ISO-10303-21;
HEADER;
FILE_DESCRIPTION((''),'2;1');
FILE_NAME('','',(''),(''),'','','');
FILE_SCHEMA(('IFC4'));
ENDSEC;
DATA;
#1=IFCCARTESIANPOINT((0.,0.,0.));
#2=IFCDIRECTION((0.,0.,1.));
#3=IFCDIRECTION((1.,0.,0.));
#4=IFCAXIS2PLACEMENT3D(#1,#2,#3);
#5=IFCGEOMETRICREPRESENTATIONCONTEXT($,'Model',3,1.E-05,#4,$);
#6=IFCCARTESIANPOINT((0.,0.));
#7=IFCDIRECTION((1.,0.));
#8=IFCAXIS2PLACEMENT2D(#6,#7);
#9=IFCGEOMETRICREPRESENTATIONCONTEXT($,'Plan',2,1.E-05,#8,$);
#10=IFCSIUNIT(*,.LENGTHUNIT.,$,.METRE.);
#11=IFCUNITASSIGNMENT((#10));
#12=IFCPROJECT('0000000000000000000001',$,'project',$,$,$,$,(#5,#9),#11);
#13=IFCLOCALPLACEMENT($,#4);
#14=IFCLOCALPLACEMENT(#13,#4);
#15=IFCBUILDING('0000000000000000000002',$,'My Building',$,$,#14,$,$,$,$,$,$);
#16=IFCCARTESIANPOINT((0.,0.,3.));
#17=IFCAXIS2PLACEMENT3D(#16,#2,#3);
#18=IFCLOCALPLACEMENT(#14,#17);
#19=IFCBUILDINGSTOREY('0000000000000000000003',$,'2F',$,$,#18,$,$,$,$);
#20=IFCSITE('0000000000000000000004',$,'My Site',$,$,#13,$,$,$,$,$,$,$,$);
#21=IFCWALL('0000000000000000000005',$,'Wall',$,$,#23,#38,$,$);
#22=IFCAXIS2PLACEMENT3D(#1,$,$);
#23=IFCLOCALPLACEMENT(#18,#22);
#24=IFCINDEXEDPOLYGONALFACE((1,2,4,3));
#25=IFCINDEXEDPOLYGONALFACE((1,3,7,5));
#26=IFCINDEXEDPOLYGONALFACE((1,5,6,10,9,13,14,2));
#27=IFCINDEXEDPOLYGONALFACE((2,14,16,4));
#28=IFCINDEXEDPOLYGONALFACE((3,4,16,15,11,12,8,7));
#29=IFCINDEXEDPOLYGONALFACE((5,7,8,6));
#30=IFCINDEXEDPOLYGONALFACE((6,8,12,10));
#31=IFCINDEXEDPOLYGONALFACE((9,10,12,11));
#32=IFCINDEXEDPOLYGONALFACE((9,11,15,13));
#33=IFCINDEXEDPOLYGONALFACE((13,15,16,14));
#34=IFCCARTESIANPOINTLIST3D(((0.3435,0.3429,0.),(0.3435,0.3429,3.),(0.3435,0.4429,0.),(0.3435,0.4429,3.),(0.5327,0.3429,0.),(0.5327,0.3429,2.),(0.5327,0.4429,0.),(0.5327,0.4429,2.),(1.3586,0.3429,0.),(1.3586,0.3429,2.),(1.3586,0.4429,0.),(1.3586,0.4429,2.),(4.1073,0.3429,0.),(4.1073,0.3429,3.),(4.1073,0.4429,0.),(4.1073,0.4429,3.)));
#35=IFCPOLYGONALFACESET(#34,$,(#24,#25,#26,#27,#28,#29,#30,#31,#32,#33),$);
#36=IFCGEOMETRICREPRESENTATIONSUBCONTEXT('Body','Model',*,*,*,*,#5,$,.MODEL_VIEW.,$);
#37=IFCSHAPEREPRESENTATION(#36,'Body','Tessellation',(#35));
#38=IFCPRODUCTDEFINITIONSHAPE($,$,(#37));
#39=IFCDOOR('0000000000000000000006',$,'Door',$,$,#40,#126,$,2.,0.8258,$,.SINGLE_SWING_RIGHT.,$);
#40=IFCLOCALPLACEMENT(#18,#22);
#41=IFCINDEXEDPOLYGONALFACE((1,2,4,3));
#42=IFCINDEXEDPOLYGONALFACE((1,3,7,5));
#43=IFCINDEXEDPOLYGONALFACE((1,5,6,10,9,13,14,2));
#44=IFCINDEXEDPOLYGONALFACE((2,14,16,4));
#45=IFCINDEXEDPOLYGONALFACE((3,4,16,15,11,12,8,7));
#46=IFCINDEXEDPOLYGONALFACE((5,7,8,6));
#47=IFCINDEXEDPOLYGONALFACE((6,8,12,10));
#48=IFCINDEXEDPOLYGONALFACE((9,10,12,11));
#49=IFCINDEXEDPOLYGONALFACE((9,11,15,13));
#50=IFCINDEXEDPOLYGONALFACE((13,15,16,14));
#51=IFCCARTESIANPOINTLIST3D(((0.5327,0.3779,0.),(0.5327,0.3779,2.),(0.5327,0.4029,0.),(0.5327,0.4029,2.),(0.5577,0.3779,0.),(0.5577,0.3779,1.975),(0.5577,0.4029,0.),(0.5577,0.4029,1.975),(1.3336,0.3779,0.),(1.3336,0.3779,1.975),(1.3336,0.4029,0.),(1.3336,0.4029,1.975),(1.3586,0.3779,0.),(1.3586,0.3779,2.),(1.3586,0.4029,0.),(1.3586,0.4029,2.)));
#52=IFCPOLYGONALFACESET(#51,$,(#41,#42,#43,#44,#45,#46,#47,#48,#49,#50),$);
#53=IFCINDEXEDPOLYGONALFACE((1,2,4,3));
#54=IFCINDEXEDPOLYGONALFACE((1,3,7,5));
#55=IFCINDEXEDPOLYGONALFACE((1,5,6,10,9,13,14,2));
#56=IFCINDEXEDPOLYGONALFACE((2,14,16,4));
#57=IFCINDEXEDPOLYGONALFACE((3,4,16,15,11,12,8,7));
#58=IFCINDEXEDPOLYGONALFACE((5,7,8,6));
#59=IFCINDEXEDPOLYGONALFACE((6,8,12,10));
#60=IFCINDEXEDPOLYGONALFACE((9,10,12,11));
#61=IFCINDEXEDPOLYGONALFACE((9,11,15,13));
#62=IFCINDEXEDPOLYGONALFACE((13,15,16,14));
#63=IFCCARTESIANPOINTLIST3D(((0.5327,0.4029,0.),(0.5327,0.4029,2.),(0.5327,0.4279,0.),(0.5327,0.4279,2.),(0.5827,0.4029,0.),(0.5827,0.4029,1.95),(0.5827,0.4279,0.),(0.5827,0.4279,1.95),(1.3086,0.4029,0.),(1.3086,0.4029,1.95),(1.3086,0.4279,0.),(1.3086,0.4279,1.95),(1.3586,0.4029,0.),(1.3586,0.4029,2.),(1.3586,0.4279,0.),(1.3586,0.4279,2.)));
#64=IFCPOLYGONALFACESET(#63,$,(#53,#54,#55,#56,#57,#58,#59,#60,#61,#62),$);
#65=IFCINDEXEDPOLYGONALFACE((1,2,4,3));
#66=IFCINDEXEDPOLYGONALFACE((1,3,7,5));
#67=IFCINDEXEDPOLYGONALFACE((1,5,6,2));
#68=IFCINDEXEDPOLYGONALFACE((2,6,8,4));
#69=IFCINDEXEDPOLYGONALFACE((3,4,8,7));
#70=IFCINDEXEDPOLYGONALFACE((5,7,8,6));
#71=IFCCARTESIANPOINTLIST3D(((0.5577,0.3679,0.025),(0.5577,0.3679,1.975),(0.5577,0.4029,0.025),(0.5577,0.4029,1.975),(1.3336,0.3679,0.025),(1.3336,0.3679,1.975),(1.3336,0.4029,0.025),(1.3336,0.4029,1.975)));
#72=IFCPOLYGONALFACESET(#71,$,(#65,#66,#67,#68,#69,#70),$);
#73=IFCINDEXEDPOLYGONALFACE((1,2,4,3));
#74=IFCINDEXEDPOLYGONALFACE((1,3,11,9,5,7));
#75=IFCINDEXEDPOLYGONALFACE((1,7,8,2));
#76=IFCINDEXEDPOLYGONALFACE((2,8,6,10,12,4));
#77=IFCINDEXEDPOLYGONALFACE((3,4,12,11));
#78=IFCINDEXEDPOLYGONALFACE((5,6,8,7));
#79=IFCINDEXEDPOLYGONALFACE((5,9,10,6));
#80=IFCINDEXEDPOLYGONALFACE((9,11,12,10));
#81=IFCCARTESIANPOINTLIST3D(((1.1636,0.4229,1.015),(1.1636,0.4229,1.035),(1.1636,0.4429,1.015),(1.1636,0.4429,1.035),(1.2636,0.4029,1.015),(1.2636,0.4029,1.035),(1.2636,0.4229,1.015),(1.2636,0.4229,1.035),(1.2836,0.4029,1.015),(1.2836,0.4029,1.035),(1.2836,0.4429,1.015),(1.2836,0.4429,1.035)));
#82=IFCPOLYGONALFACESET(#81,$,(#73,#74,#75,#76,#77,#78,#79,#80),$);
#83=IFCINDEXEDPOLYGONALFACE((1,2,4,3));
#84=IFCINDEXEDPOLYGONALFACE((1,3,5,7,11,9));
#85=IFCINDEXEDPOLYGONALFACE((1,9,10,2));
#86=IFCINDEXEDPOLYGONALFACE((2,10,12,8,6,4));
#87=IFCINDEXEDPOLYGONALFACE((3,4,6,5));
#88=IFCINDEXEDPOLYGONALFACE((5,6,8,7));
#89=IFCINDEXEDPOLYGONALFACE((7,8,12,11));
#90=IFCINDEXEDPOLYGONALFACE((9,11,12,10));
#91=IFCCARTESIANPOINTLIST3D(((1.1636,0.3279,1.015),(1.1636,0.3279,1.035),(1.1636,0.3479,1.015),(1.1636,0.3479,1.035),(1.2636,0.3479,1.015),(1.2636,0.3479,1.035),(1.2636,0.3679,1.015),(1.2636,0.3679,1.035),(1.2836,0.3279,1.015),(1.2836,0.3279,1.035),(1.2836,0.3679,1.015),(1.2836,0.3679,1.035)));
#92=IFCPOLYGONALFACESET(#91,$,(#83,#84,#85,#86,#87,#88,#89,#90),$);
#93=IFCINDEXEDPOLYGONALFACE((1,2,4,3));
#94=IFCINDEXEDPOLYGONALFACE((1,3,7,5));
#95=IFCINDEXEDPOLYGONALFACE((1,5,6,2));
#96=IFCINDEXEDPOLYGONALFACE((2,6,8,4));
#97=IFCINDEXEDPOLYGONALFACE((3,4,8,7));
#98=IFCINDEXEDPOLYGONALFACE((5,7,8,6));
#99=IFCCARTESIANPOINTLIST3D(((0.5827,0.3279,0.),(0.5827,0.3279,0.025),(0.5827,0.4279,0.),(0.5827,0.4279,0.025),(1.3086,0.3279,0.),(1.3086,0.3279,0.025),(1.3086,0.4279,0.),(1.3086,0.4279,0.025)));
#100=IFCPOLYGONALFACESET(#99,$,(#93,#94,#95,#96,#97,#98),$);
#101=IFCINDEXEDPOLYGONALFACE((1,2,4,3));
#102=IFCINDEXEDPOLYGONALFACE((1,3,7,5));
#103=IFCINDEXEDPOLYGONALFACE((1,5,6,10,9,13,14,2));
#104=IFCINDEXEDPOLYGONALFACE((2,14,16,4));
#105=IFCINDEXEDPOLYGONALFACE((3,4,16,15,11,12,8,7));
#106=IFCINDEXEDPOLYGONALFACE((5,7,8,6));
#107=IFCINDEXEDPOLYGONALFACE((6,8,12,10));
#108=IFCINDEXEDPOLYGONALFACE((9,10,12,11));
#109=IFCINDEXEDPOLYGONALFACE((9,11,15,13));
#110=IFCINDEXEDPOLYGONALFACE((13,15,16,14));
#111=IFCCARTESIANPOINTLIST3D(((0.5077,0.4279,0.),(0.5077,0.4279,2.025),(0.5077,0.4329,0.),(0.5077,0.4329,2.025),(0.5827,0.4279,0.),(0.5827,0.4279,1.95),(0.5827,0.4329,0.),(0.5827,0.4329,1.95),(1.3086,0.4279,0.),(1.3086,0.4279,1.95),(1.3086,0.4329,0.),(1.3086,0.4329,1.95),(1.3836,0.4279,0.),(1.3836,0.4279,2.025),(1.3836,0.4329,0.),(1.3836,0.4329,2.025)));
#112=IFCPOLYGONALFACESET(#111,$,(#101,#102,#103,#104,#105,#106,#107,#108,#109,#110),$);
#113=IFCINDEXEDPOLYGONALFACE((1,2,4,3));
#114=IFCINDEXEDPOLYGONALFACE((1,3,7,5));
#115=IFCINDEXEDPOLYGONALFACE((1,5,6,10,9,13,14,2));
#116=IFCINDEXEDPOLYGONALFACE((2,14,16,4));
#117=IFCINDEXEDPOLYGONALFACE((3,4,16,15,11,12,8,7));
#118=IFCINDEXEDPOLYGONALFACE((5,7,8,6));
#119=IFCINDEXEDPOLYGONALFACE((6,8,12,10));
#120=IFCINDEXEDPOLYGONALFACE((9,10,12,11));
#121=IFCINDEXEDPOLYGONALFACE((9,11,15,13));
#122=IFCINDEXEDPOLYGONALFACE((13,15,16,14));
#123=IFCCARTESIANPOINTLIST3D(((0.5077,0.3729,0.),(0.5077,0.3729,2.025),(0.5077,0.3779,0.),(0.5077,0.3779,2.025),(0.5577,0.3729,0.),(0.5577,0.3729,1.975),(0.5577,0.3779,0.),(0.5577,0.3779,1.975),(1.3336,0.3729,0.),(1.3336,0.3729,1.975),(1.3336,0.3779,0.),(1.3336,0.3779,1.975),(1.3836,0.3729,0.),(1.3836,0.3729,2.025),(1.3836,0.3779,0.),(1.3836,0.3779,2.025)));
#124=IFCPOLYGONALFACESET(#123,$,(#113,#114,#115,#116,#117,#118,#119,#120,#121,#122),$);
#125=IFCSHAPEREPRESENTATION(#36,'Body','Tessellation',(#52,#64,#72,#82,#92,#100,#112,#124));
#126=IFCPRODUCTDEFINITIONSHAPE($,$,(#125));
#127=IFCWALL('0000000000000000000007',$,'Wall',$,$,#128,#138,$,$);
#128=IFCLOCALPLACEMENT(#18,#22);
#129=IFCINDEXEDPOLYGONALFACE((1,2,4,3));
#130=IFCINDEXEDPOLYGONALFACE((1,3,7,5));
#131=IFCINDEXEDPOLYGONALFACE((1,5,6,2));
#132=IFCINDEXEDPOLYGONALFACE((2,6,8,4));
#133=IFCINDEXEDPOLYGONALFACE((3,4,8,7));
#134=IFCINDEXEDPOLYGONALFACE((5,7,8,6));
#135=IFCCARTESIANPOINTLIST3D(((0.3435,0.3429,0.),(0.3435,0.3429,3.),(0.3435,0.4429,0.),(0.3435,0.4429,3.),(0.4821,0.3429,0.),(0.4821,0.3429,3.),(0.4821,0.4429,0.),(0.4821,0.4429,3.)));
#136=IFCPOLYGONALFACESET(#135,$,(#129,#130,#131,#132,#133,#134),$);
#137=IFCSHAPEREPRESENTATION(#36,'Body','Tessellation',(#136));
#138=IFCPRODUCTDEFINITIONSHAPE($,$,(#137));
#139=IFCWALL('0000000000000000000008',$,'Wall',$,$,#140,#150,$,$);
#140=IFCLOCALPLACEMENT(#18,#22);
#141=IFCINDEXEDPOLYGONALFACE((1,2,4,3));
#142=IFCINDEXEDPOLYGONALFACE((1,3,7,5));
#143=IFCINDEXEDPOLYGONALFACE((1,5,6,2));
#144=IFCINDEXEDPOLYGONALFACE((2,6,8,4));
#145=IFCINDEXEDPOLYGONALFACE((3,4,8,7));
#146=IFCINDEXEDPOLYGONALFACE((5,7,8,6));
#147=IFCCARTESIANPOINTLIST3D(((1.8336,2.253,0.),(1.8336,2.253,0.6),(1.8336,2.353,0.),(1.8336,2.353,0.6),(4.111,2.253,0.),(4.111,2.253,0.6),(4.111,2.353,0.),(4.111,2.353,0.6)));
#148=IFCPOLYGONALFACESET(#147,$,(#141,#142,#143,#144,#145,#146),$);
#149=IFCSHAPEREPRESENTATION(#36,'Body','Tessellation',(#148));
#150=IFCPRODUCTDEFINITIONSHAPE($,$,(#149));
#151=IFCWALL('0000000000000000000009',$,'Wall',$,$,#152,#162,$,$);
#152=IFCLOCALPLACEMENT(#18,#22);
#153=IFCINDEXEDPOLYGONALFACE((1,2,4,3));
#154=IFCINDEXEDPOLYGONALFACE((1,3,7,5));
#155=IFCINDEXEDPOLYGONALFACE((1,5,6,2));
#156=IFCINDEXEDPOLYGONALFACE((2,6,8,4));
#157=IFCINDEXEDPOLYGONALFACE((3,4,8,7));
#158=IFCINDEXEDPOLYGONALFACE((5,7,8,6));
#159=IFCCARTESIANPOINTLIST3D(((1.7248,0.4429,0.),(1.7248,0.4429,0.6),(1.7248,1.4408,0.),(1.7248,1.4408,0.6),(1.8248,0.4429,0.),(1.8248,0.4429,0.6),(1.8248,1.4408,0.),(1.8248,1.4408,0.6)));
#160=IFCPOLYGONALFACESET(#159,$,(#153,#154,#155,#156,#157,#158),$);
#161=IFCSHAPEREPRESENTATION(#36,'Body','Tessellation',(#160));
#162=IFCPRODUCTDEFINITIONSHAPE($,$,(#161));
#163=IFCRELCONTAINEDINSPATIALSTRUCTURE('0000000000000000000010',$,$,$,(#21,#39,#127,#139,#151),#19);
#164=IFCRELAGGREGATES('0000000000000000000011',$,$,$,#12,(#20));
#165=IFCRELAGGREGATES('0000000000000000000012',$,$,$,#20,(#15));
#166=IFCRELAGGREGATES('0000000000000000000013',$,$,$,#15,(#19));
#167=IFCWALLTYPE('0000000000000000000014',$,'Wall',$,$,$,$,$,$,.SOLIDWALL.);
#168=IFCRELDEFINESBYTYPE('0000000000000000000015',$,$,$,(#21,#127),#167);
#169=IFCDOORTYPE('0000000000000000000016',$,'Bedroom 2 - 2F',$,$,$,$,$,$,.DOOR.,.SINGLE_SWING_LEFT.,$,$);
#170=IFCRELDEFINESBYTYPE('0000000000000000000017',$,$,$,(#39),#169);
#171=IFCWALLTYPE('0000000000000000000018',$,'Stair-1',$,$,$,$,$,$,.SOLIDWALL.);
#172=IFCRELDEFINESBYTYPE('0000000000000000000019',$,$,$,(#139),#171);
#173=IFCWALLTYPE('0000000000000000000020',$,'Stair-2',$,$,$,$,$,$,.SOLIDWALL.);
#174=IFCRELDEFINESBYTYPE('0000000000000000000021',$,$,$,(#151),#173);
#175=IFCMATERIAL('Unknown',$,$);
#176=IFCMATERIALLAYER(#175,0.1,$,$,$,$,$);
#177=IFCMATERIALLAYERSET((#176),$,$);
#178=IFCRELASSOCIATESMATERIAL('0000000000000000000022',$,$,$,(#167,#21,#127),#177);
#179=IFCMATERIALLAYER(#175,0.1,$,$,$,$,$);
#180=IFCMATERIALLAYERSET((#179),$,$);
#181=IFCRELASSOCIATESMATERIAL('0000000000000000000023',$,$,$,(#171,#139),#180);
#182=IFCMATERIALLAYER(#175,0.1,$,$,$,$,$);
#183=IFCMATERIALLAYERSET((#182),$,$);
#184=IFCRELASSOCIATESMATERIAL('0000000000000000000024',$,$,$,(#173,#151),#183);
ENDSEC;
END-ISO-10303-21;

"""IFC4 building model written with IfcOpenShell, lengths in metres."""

from ifc_helpers import new_model, entity, si_unit, frame, origin_with_axes, origin_2d_with_axis, place, context, subcontext, project, spatial, line, indexed_curve, outline, extrude, shape, source, transform, mapped, material, layer, layer_set, layer_usage, type_object, type_shapes, element, fill, save


model = new_model("IFC4")

# Units and contexts
model_context = context("Model", 3, precision=1e-05, world=origin_with_axes())
plan_context = context("Plan", 2, precision=1e-05, world=origin_2d_with_axis())
body_context_1 = subcontext(model_context, "Body", "Model", "MODEL_VIEW")
body_context_2 = subcontext(plan_context, "Body", "Plan", "PLAN_VIEW")
ifc_project = project(units=[si_unit("LENGTHUNIT", "METRE")], contexts=[model_context, plan_context])

# Site, building, storey
site_placement = place(None, origin_with_axes())
site = spatial("IfcSite", under=ifc_project, at=site_placement, Name="My Site")
building_placement = place(site_placement, origin_with_axes())
building = spatial("IfcBuilding", under=site, at=building_placement, Name="My Building")
storey_placement = place(building_placement, frame((0.0, 0.0, 3.0), z_axis=(0.0, 0.0, 1.0), x_axis=(1.0, 0.0, 0.0)))
storey = spatial("IfcBuildingStorey", under=building, at=storey_placement, Name="2F")

# Shared definitions
ifc_material_1 = material(Name="Unknown")
ifc_layer_1 = layer(ifc_material_1, 0.1)
ifc_layer_set_1 = layer_set([ifc_layer_1])
wall_type_1 = type_object("IfcWallType", Name="Wall", PredefinedType="SOLIDWALL", material=ifc_layer_set_1)

# Wall, opening, door
ifc_layer_usage_1 = layer_usage(ifc_layer_set_1, "AXIS2", "POSITIVE", 0.0)
wall_1_placement = place(storey_placement, frame((4.2073, 0.4429, 0.0), z_axis=(0.0, 0.0, 1.0), x_axis=(-1.0, 0.0, 0.0)))
wall_1 = element("IfcWall", 1, at=wall_1_placement, inside=storey, type_object=wall_type_1, material=ifc_layer_usage_1, Name="Wall", context=body_context_1, shape_type="SweptSolid", body=[
    extrude(outline(indexed_curve([(0.1, 0.0), (0.1, 0.1), (3.8638, 0.1), (3.8638, 0.0)], segments=[line(1, 2, 3, 4, 1)])), origin_with_axes(), (0.0, 0.0, 1.0), 3.0),
])
shared_shape_1 = source(origin_with_axes(), body_context_1, "Body", "SweptSolid", [
    extrude(outline(indexed_curve([(0.0, 0.0), (0.8258, 0.0), (0.8258, 2.0), (0.0, 2.0)], segments=[line(1, 2, 3, 4, 1)])), frame((0.0, -0.6, 0.0), z_axis=(0.0, -1.0, 0.0), x_axis=(1.0, 0.0, 0.0)), (0.0, 0.0, -1.0), 1.2),
])
opening_1_placement = place(wall_1_placement, frame((2.8487, 0.015, 0.0), z_axis=(0.0, 0.0, 1.0), x_axis=(1.0, -0.000001, 0.0)))
opening_1 = element("IfcOpeningElement", 2, at=opening_1_placement, cuts=wall_1, PredefinedType="OPENING", context=body_context_1, shape_type="MappedRepresentation", body=[
    mapped(shared_shape_1, transform((0.0, 0.0, 0.0), x_axis=(1.0, 0.0, 0.0), y_axis=(0.0, 1.0, 0.0), z_axis=(0.0, 0.0, 1.0), scale=1.0)),
])
door_type_1 = type_object("IfcDoorType", Name="Bedroom 2 - 2F", OperationType="SINGLE_SWING_LEFT", PredefinedType="DOOR")
shared_shape_2 = source(origin_with_axes(), body_context_1, "Body", "SweptSolid", [
    extrude(outline(indexed_curve([(0.0, 0.0), (0.0, 2.0), (0.8258, 2.0), (0.8258, 0.0), (0.8008, 0.0), (0.8008, 1.975), (0.025, 1.975), (0.025, 0.0)], segments=[line(1, 2, 3, 4, 5, 6, 7, 8, 1)])), frame((0.0, 0.025, 0.0), z_axis=(0.0, -1.0, 0.0), x_axis=(1.0, 0.0, 0.0)), (0.0, 0.0, -1.0), 0.025),
    extrude(outline(indexed_curve([(0.0, 0.0), (0.0, 2.0), (0.8258, 2.0), (0.8258, 0.0), (0.7758, 0.0), (0.7758, 1.95), (0.05, 1.95), (0.05, 0.0)], segments=[line(1, 2, 3, 4, 5, 6, 7, 8, 1)])), frame((0.0, 0.0, 0.0), z_axis=(0.0, -1.0, 0.0), x_axis=(1.0, 0.0, 0.0)), (0.0, 0.0, -1.0), 0.025),
    extrude(outline(indexed_curve([(0.0, 0.0), (0.7758, 0.0), (0.7758, 0.035), (0.0, 0.035)], segments=[line(1, 2, 3, 4, 1)])), frame((0.025, 0.025, 0.025), z_axis=(0.0, 0.0, 1.0), x_axis=(1.0, 0.0, 0.0)), (0.0, 0.0, 1.0), 1.95),
    extrude(outline(indexed_curve([(0.0, 0.0), (0.0, -0.04), (0.12, -0.04), (0.12, -0.02), (0.02, -0.02), (0.02, 0.0)], segments=[line(1, 2, 3, 4, 5, 6, 1)])), frame((0.075, 0.025, 1.015), z_axis=(0.0, 0.0, 1.0), x_axis=(1.0, 0.0, 0.0)), (0.0, 0.0, 1.0), 0.02),
    extrude(outline(indexed_curve([(0.0, 0.0), (0.0, 0.04), (0.12, 0.04), (0.12, 0.02), (0.02, 0.02), (0.02, 0.0)], segments=[line(1, 2, 3, 4, 5, 6, 1)])), frame((0.075, 0.06, 1.015), z_axis=(0.0, 0.0, 1.0), x_axis=(1.0, 0.0, 0.0)), (0.0, 0.0, 1.0), 0.02),
    extrude(outline(indexed_curve([(0.0, 0.0), (0.7258, 0.0), (0.7258, 0.1), (0.0, 0.1)], segments=[line(1, 2, 3, 4, 1)])), frame((0.05, 0.0, 0.0), z_axis=(0.0, 0.0, 1.0), x_axis=(1.0, 0.0, 0.0)), (0.0, 0.0, 1.0), 0.025),
    extrude(outline(indexed_curve([(0.0, 0.0), (0.0, 2.025), (0.8758, 2.025), (0.8758, 0.0), (0.8008, 0.0), (0.8008, 1.95), (0.075, 1.95), (0.075, 0.0)], segments=[line(1, 2, 3, 4, 5, 6, 7, 8, 1)])), frame((-0.025, -0.005, 0.0), z_axis=(0.0, -1.0, 0.0), x_axis=(1.0, 0.0, 0.0)), (0.0, 0.0, -1.0), 0.005),
    extrude(outline(indexed_curve([(0.0, 0.0), (0.0, 2.025), (0.8758, 2.025), (0.8758, 0.0), (0.8258, 0.0), (0.8258, 1.975), (0.05, 1.975), (0.05, 0.0)], segments=[line(1, 2, 3, 4, 5, 6, 7, 8, 1)])), frame((-0.025, 0.05, 0.0), z_axis=(0.0, -1.0, 0.0), x_axis=(1.0, 0.0, 0.0)), (0.0, 0.0, -1.0), 0.005),
])
shared_shape_3 = source(origin_with_axes(), body_context_2, "Body", "Curve2D", [
    entity("IfcIndexedPolyCurve", entity("IfcCartesianPointList2D", [[0.0, 0.0], [0.0, 0.05], [0.025, 0.05], [0.025, 0.025], [0.05, 0.025], [0.05, 0.0]]), [entity("IfcLineIndex", [1, 2, 3, 4, 5, 6, 1])]),
    entity("IfcIndexedPolyCurve", entity("IfcCartesianPointList2D", [[0.8258, 0.0], [0.8258, 0.05], [0.8008, 0.05], [0.8008, 0.025], [0.7758, 0.025], [0.7758, 0.0]]), [entity("IfcLineIndex", [1, 2, 3, 4, 5, 6, 1])]),
    entity("IfcTrimmedCurve", entity("IfcEllipse", entity("IfcAxis2Placement2D", entity("IfcCartesianPoint", [0.7658, 0.05]), entity("IfcDirection", [1.0, 0.0])), 0.7408, 0.7758), [entity("IfcCartesianPoint", [0.7658, 0.8258])], [entity("IfcCartesianPoint", [0.025, 0.05])], True, "CARTESIAN"),
    entity("IfcIndexedPolyCurve", entity("IfcCartesianPointList2D", [[0.8008, 0.05], [0.7658, 0.05], [0.7658, 0.8258], [0.8008, 0.8258]]), [entity("IfcLineIndex", [1, 2, 3, 4, 1])]),
])
type_shapes(door_type_1, [shared_shape_2, shared_shape_3])
door_1_placement = place(opening_1_placement, frame((0.0, 0.0, 0.0), z_axis=(0.0, 0.0, 1.0), x_axis=(1.0, 0.0, 0.0)))
door_1 = element("IfcDoor", 3, at=door_1_placement, inside=storey, type_object=door_type_1, Name="Door", OperationType="SINGLE_SWING_RIGHT", OverallHeight=2.0, OverallWidth=0.8258, shapes=[
    shape(body_context_1, "Body", "MappedRepresentation", [mapped(shared_shape_2, transform((0.0, 0.0, 0.0), x_axis=(1.0, 0.0, 0.0), y_axis=(0.0, 1.0, 0.0), z_axis=(0.0, 0.0, 1.0), scale=1.0))]),
    shape(body_context_2, "Body", "MappedRepresentation", [mapped(shared_shape_3, transform((0.0, 0.0, 0.0), x_axis=(1.0, 0.0, 0.0), y_axis=(0.0, 1.0, 0.0), z_axis=(0.0, 0.0, 1.0), scale=1.0))]),
])
fill(opening_1, door_1)

# Walls
ifc_layer_usage_2 = layer_usage(ifc_layer_set_1, "AXIS2", "POSITIVE", 0.0)
wall_2_placement = place(storey_placement, frame((0.4821, 0.4429, 0.0), z_axis=(0.0, 0.0, 1.0), x_axis=(-1.0, 0.0, 0.0)))
element("IfcWall", 4, at=wall_2_placement, inside=storey, type_object=wall_type_1, material=ifc_layer_usage_2, Name="Wall", context=body_context_1, shape_type="SweptSolid", body=[
    extrude(outline(indexed_curve([(0.0, 0.0), (0.0, 0.1), (0.1387, 0.1), (0.1387, 0.0)], segments=[line(1, 2, 3, 4, 1)])), origin_with_axes(), (0.0, 0.0, 1.0), 3.0),
])
ifc_layer_2 = layer(ifc_material_1, 0.1)
ifc_layer_set_2 = layer_set([ifc_layer_2])
ifc_layer_usage_3 = layer_usage(ifc_layer_set_2, "AXIS2", "POSITIVE", 0.0)
wall_type_2 = type_object("IfcWallType", Name="Stair-1", PredefinedType="SOLIDWALL", material=ifc_layer_set_2)
wall_3_placement = place(storey_placement, frame((1.8336, 2.253, 0.0), z_axis=(0.0, 0.0, 1.0), x_axis=(1.0, 0.0, 0.0)))
element("IfcWall", 5, at=wall_3_placement, inside=storey, type_object=wall_type_2, material=ifc_layer_usage_3, Name="Wall", context=body_context_1, shape_type="SweptSolid", body=[
    extrude(outline(indexed_curve([(0.0, 0.0), (0.0, 0.1), (2.2773, 0.1), (2.2773, 0.0)], segments=[line(1, 2, 3, 4, 1)])), origin_with_axes(), (0.0, 0.0, 1.0), 0.6),
])
ifc_layer_3 = layer(ifc_material_1, 0.1)
ifc_layer_set_3 = layer_set([ifc_layer_3])
ifc_layer_usage_4 = layer_usage(ifc_layer_set_3, "AXIS2", "POSITIVE", 0.0)
wall_type_3 = type_object("IfcWallType", Name="Stair-2", PredefinedType="SOLIDWALL", material=ifc_layer_set_3)
wall_4_placement = place(storey_placement, frame((1.8248, 0.4429, 0.0), z_axis=(0.0, 0.0, 1.0), x_axis=(0.0, 1.0, 0.0)))
element("IfcWall", 6, at=wall_4_placement, inside=storey, type_object=wall_type_3, material=ifc_layer_usage_4, Name="Wall", context=body_context_1, shape_type="SweptSolid", body=[
    extrude(outline(indexed_curve([(0.0, 0.0), (0.0, 0.1), (0.9979, 0.1), (0.9979, 0.0)], segments=[line(1, 2, 3, 4, 1)])), origin_with_axes(), (0.0, 0.0, 1.0), 0.6),
])

save(model, "model.ifc")
